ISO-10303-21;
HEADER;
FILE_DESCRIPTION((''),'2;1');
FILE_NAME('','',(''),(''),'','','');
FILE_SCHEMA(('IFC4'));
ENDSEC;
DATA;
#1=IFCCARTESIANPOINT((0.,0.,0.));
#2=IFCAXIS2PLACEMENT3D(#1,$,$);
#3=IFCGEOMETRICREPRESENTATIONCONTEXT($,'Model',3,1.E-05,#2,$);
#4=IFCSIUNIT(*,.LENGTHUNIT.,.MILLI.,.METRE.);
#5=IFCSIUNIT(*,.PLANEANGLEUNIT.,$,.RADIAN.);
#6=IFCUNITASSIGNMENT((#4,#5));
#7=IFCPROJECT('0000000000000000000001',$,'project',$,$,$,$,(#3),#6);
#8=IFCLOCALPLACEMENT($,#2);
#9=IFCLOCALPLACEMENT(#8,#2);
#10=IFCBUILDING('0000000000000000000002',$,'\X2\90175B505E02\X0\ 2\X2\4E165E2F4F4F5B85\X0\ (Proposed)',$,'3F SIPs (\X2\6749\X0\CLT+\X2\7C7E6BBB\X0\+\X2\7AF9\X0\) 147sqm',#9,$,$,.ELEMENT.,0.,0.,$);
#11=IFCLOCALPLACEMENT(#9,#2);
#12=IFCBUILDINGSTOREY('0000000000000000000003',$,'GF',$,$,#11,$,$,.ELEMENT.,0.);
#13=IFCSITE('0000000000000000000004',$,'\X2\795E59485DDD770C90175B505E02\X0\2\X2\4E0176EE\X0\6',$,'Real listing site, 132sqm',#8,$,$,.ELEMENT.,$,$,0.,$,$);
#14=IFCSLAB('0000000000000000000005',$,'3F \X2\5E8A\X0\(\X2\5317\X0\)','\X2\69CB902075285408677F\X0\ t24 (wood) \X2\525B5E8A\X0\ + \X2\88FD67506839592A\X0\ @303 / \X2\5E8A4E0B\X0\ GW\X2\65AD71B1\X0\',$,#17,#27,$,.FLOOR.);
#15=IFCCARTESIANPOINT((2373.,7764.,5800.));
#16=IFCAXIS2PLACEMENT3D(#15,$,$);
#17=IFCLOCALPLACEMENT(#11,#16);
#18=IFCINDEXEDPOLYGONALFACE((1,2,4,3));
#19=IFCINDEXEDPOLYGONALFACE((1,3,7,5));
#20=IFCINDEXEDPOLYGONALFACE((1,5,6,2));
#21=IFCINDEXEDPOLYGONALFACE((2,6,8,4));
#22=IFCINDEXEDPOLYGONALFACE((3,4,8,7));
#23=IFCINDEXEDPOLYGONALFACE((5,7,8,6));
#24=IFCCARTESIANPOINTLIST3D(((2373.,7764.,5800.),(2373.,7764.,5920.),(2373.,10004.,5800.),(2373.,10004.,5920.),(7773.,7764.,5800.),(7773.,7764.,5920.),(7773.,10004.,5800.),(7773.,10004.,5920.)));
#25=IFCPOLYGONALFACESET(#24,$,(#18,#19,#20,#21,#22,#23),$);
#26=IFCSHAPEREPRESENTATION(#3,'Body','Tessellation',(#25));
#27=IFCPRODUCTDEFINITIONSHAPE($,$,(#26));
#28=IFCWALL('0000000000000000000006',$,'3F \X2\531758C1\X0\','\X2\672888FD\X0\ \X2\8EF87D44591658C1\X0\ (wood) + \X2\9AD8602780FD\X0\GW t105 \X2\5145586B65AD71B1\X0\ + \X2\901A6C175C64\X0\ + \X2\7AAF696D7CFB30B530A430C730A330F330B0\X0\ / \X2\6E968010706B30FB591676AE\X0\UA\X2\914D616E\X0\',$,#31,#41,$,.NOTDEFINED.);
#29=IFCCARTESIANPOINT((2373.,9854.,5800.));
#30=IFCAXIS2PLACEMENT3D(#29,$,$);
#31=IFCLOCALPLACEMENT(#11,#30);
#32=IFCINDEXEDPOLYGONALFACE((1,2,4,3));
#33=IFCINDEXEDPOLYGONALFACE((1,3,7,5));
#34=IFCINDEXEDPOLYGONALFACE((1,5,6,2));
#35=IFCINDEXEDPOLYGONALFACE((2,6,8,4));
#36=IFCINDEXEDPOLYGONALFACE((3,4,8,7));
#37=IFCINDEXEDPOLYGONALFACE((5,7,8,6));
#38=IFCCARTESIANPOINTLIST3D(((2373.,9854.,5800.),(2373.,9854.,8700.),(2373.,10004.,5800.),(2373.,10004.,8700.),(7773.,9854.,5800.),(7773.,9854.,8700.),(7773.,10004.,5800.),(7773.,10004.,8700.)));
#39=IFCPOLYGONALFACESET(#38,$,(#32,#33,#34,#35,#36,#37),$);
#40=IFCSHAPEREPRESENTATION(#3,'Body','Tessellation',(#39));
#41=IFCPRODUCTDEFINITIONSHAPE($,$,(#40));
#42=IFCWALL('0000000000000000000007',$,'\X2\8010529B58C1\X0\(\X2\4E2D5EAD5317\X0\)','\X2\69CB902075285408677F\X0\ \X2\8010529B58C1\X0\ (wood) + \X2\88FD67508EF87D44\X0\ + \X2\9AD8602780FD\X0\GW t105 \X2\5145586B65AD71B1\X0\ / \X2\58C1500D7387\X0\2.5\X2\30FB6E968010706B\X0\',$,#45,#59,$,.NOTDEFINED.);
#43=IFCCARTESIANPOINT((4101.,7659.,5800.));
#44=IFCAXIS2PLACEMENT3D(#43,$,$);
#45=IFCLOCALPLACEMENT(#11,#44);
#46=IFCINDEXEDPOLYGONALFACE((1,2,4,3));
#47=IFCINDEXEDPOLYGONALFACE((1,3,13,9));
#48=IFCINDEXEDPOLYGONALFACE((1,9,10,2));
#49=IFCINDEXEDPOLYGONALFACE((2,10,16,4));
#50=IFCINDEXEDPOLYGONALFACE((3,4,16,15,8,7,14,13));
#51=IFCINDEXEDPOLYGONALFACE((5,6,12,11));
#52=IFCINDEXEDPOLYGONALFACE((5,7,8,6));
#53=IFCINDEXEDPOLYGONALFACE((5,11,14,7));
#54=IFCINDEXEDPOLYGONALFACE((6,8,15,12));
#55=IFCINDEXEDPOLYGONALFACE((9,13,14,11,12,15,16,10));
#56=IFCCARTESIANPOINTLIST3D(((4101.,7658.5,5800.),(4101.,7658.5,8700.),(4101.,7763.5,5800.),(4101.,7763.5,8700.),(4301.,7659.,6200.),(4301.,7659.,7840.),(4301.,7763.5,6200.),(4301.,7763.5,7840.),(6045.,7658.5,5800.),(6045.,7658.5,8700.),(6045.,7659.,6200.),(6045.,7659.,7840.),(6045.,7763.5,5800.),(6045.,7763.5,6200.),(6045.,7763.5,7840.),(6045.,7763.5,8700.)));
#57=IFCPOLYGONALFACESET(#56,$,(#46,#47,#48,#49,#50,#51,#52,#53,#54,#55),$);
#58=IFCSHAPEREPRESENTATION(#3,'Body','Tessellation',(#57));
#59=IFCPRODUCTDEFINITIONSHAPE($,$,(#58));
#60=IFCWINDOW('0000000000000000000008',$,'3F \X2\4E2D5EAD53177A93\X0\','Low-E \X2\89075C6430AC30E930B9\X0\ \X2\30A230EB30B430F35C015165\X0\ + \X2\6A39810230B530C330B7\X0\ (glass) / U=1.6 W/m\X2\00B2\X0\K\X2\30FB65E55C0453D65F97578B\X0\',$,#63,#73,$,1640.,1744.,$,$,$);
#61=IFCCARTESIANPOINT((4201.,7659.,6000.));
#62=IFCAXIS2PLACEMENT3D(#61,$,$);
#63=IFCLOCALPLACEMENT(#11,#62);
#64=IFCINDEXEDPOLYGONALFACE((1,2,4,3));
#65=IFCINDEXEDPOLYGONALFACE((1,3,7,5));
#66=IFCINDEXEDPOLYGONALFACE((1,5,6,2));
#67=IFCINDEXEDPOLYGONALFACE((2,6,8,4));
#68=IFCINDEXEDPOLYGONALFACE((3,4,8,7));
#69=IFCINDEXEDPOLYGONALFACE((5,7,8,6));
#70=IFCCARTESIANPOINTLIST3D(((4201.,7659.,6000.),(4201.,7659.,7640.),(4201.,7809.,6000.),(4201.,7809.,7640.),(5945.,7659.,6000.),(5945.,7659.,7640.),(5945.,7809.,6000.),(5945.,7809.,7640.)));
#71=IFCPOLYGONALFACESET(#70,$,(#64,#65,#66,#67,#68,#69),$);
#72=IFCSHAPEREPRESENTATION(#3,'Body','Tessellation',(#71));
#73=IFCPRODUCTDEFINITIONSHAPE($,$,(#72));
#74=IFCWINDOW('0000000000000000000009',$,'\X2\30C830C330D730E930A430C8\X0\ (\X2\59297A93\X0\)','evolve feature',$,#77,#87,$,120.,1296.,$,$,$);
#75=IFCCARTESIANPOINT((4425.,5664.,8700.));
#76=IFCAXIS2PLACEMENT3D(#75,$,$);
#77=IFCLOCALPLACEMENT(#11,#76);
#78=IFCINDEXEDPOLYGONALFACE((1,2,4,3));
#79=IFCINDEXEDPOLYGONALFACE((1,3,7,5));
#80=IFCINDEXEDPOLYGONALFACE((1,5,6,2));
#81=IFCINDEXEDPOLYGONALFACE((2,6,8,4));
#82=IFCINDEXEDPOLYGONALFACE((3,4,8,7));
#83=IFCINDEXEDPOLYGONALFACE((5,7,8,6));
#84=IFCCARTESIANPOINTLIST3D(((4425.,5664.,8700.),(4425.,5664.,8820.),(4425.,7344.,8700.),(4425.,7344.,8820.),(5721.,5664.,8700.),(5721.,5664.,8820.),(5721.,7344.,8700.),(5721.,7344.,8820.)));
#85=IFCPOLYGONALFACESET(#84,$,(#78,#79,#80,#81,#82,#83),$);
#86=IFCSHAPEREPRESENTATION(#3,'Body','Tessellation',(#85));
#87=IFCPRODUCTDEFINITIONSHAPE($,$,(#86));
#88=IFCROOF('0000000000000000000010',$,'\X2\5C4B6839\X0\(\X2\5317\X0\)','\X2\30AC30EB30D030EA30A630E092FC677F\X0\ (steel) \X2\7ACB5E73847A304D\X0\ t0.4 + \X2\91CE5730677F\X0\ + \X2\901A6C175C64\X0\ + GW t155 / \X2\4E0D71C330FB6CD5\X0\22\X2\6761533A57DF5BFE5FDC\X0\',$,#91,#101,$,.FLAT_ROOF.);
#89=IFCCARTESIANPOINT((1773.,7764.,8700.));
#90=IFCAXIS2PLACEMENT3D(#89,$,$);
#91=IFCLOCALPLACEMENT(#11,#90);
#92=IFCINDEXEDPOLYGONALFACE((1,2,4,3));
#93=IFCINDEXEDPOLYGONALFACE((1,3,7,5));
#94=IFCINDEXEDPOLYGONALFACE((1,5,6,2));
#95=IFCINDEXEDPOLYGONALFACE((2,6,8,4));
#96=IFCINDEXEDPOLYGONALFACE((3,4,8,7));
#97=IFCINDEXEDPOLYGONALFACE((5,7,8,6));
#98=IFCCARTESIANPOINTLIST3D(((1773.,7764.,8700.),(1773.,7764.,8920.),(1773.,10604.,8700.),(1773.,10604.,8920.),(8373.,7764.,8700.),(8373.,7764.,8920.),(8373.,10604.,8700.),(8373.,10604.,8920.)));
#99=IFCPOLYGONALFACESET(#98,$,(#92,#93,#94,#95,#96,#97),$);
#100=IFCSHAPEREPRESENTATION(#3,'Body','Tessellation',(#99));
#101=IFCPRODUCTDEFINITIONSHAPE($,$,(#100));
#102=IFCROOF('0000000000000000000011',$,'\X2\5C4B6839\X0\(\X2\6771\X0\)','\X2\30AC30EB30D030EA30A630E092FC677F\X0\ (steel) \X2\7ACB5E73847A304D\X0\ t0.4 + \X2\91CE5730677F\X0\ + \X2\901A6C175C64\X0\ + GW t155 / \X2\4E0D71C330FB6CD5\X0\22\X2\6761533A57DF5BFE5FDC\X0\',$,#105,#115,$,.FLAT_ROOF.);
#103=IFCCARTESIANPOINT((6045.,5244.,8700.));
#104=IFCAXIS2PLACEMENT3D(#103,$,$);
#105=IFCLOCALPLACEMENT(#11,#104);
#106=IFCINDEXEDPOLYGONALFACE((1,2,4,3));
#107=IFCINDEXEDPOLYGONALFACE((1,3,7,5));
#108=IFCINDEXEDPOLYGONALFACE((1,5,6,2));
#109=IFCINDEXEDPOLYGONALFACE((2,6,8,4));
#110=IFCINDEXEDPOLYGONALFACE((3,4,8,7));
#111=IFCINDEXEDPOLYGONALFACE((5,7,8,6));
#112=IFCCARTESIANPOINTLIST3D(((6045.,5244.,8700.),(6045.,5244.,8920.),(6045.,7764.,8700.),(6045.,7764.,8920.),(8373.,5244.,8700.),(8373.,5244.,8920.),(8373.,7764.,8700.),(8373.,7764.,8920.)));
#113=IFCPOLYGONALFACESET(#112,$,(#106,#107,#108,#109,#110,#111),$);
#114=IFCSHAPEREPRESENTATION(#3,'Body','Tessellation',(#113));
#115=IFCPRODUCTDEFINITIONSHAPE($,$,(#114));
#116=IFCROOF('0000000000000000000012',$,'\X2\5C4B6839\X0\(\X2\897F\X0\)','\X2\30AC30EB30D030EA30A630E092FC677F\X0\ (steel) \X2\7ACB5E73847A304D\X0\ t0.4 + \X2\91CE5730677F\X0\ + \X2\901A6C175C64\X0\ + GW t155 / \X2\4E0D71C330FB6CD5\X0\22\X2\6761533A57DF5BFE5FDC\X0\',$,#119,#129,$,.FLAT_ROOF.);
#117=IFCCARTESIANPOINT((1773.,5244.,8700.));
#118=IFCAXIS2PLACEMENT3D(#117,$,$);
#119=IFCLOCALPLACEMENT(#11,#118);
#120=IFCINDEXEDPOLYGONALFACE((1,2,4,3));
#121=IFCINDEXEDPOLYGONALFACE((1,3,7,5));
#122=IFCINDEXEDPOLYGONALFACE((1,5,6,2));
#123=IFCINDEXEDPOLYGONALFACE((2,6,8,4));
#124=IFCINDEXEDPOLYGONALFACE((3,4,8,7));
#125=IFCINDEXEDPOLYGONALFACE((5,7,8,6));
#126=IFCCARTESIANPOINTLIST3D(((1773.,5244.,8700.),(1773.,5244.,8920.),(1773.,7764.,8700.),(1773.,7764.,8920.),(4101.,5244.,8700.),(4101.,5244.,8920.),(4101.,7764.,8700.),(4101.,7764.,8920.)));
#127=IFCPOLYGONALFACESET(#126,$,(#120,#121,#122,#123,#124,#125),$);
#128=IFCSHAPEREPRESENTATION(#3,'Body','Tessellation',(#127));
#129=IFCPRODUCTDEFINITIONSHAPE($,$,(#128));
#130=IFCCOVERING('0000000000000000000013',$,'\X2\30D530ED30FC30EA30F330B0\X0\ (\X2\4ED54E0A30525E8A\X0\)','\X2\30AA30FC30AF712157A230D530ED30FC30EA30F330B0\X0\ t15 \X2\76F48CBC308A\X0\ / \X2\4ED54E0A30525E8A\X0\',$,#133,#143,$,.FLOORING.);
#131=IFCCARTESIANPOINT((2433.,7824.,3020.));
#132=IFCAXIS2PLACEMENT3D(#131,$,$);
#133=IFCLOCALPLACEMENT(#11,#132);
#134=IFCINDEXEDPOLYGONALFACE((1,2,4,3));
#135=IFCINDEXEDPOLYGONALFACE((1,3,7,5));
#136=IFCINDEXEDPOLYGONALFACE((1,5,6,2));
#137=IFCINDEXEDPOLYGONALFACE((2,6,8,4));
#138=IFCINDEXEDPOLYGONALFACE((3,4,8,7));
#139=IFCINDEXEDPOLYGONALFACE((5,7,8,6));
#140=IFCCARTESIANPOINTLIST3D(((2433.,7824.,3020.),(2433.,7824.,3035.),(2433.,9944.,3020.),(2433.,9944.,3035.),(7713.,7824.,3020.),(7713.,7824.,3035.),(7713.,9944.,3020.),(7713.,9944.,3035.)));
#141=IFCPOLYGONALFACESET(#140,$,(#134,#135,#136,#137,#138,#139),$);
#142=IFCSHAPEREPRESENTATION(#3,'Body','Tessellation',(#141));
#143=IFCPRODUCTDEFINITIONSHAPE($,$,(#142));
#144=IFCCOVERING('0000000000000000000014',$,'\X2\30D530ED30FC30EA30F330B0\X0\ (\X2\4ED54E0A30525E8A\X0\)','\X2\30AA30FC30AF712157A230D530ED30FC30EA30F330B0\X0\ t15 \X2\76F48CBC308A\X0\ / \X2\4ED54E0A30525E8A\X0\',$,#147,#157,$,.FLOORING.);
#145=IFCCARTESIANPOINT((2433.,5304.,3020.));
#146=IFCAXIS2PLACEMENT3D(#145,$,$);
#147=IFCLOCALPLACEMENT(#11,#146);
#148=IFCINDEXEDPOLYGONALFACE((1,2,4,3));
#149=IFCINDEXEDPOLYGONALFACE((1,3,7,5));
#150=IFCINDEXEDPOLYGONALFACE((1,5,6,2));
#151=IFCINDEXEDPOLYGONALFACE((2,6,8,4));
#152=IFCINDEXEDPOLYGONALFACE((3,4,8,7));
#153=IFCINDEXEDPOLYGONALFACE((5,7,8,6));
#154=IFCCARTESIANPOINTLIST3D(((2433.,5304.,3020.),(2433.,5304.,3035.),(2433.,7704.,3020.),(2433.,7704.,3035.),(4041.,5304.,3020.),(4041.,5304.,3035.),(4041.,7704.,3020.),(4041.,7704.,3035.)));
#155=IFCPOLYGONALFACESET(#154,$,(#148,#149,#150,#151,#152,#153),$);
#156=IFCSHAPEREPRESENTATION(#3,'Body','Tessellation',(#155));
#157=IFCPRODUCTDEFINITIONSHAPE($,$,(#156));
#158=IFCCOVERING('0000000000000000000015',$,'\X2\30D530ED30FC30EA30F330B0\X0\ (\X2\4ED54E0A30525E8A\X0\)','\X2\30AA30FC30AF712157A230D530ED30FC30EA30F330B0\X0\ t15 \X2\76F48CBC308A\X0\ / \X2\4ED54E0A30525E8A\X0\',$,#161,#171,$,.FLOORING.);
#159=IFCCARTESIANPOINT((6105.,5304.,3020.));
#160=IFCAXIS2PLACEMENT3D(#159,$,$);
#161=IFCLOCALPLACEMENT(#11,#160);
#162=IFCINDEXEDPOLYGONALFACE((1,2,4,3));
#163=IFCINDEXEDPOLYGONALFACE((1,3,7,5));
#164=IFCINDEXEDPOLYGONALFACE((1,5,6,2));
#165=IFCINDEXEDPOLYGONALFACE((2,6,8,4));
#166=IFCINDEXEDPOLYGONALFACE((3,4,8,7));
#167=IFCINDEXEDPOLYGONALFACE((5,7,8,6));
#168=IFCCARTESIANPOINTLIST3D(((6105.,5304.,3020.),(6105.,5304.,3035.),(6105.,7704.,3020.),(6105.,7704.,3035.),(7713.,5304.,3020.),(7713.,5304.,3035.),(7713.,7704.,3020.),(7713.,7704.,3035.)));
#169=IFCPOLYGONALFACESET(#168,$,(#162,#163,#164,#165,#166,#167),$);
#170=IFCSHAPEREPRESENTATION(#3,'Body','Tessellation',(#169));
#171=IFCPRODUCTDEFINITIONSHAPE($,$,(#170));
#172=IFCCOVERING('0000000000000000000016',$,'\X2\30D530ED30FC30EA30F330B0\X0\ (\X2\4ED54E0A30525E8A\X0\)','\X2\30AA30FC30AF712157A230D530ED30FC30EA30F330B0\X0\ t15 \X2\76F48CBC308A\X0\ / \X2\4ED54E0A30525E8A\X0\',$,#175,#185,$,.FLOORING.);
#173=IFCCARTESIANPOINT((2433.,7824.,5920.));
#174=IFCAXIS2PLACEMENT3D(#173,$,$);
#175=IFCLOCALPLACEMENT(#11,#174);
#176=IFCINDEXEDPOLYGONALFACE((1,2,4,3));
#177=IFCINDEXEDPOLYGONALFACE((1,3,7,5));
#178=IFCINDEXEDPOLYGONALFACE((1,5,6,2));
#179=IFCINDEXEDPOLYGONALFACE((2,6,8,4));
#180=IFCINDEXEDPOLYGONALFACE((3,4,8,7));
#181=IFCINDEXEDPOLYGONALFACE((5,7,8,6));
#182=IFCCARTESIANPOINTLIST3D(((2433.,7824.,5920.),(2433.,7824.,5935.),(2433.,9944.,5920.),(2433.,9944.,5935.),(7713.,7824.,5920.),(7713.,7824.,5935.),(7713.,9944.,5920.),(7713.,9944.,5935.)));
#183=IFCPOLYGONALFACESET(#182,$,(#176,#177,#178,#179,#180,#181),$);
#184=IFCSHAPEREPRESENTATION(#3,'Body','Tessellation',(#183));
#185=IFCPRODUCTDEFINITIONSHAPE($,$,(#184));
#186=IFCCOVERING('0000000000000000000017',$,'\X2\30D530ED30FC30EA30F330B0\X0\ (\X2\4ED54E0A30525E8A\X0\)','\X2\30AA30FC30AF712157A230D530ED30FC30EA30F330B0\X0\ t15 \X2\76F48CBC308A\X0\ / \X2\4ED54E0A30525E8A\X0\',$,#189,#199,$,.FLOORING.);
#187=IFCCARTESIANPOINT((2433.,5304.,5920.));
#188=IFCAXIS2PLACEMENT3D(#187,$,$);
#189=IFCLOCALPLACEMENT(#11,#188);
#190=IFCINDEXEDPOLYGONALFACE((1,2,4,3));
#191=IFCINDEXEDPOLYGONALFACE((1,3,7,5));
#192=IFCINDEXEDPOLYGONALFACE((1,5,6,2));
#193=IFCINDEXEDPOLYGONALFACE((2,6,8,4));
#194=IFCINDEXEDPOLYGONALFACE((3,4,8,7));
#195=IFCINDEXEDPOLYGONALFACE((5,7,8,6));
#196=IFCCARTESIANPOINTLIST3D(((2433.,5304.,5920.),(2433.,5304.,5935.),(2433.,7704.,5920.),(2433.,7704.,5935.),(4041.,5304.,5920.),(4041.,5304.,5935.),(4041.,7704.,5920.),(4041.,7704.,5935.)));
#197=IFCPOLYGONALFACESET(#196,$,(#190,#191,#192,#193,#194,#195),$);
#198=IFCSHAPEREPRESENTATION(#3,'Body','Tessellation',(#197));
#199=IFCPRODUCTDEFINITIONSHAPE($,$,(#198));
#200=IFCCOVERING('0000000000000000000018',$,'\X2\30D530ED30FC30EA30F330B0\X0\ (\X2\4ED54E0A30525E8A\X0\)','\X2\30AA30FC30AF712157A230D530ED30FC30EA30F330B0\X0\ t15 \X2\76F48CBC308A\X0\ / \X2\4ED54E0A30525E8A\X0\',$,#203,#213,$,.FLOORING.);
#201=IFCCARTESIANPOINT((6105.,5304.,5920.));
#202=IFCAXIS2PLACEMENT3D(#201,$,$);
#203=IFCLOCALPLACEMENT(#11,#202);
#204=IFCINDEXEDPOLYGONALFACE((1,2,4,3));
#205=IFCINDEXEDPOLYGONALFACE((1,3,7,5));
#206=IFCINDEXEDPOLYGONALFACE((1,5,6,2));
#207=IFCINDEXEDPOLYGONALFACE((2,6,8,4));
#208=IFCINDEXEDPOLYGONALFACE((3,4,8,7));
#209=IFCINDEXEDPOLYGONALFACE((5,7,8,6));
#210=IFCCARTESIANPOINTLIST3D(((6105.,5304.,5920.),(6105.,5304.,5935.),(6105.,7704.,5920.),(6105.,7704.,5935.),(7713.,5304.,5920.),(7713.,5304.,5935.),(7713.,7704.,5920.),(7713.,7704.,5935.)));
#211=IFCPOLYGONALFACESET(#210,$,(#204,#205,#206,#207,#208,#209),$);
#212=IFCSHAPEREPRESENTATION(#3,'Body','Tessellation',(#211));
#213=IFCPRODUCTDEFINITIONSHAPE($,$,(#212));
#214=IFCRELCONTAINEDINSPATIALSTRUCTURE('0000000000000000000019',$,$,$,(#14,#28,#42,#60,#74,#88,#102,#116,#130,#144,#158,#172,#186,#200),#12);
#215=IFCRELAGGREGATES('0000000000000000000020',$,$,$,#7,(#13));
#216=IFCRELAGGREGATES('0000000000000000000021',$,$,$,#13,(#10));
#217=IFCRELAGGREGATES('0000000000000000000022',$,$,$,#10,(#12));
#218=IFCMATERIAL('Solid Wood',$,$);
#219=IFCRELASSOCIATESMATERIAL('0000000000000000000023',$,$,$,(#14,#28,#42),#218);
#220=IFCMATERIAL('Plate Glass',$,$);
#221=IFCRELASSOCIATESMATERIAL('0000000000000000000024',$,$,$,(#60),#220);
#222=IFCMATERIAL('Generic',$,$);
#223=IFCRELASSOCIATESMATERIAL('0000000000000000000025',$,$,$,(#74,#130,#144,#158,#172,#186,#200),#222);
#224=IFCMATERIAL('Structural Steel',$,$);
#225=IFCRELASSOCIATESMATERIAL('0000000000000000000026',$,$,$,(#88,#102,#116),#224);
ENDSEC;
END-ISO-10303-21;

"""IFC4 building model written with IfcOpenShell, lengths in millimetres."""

from ifc_helpers import new_model, si_unit, frame, frame_2d, origin, place, context, project, spatial, rectangle, extrude, material, element, fill, save


model = new_model("IFC4")

# Units and contexts
model_context = context("Model", 3, precision=1e-05, world=origin())
ifc_project = project(units=[si_unit("LENGTHUNIT", "METRE", prefix="MILLI"), si_unit("PLANEANGLEUNIT", "RADIAN")], contexts=[model_context])

# Site, building, storey
site_placement = place(None, origin())
site = spatial("IfcSite", under=ifc_project, at=site_placement, Name="神奈川県逗子市2丁目6", ObjectType="Real listing site, 132sqm", CompositionType="ELEMENT", RefElevation=0.0)
building_placement = place(site_placement, origin())
building = spatial("IfcBuilding", under=site, at=building_placement, Name="逗子市 2世帯住宅 (Proposed)", ObjectType="3F SIPs (杉CLT+籾殻+竹) 147sqm", CompositionType="ELEMENT", ElevationOfRefHeight=0.0, ElevationOfTerrain=0.0)
storey_placement = place(building_placement, origin())
storey = spatial("IfcBuildingStorey", under=building, at=storey_placement, Name="GF", CompositionType="ELEMENT", Elevation=0.0)

# Slab
ifc_material_1 = material(Name="Solid Wood")
slab_placement = place(storey_placement, frame((2373.0, 7764.0, 5800.0)))
element("IfcSlab", 1, at=slab_placement, inside=storey, material=ifc_material_1, Name="3F 床(北)", Description="構造用合板 t24 (wood) 剛床 + 製材根太 @303 / 床下 GW断熱", PredefinedType="FLOOR", context=model_context, shape_type="SweptSolid", body=[
    extrude(rectangle(XDim=5400.0, YDim=2240.0, at=frame_2d((2700.0, 1120.0))), frame((2373.0, 7764.0, 5800.0)), (0.0, 0.0, 1.0), 120.0),
])

# Wall
wall_1_placement = place(storey_placement, frame((2373.0, 9854.0, 5800.0)))
element("IfcWall", 2, at=wall_1_placement, inside=storey, material=ifc_material_1, Name="3F 北壁", Description="木製 軸組外壁 (wood) + 高性能GW t105 充填断熱 + 通気層 + 窯業系サイディング / 準耐火・外皮UA配慮", PredefinedType="NOTDEFINED", context=model_context, shape_type="SweptSolid", body=[
    extrude(rectangle(XDim=5400.0, YDim=150.0, at=frame_2d((2700.0, 75.0))), frame((2373.0, 9854.0, 5800.0)), (0.0, 0.0, 1.0), 2900.0),
])

# Wall, opening, window
wall_2_placement = place(storey_placement, frame((4101.0, 7659.0, 5800.0)))
wall_2 = element("IfcWall", 3, at=wall_2_placement, inside=storey, material=ifc_material_1, Name="耐力壁(中庭北)", Description="構造用合板 耐力壁 (wood) + 製材軸組 + 高性能GW t105 充填断熱 / 壁倍率2.5・準耐火", PredefinedType="NOTDEFINED", context=model_context, shape_type="SweptSolid", body=[
    extrude(rectangle(XDim=1944.0, YDim=105.0, at=frame_2d((972.0, 52.0))), frame((4101.0, 7659.0, 5800.0)), (0.0, 0.0, 1.0), 2900.0),
])
opening_placement = place(storey_placement, frame((4201.0, 7659.0, 6000.0)))
opening = element("IfcOpeningElement", 4, at=opening_placement, cuts=wall_2, PredefinedType="NOTDEFINED", context=model_context, shape_type="SweptSolid", body=[
    extrude(rectangle(XDim=1744.0, YDim=150.0, at=frame_2d((872.0, 75.0))), frame((4201.0, 7659.0, 6000.0)), (0.0, 0.0, 1.0), 1640.0),
])
ifc_material_2 = material(Name="Plate Glass")
window_1_placement = place(storey_placement, frame((4201.0, 7659.0, 6000.0)))
window_1 = element("IfcWindow", 5, at=window_1_placement, inside=storey, material=ifc_material_2, Name="3F 中庭北窓", Description="Low-E 複層ガラス アルゴン封入 + 樹脂サッシ (glass) / U=1.6 W/m²K・日射取得型", OverallHeight=1640.0, OverallWidth=1744.0, context=model_context, shape_type="SweptSolid", body=[
    extrude(rectangle(XDim=1744.0, YDim=150.0, at=frame_2d((872.0, 75.0))), frame((4201.0, 7659.0, 6000.0)), (0.0, 0.0, 1.0), 1640.0),
])
fill(opening, window_1)

# Window
ifc_material_3 = material(Name="Generic")
window_2_placement = place(storey_placement, frame((4425.0, 5664.0, 8700.0)))
element("IfcWindow", 6, at=window_2_placement, inside=storey, material=ifc_material_3, Name="トップライト (天窓)", Description="evolve feature", OverallHeight=120.0, OverallWidth=1296.0, context=model_context, shape_type="SweptSolid", body=[
    extrude(rectangle(XDim=1296.0, YDim=1680.0, at=frame_2d((648.0, 840.0))), frame((4425.0, 5664.0, 8700.0)), (0.0, 0.0, 1.0), 120.0),
])

# Roofs
ifc_material_4 = material(Name="Structural Steel")
roof_1_placement = place(storey_placement, frame((1773.0, 7764.0, 8700.0)))
element("IfcRoof", 7, at=roof_1_placement, inside=storey, material=ifc_material_4, Name="屋根(北)", Description="ガルバリウム鋼板 (steel) 立平葺き t0.4 + 野地板 + 通気層 + GW t155 / 不燃・法22条区域対応", PredefinedType="FLAT_ROOF", context=model_context, shape_type="SweptSolid", body=[
    extrude(rectangle(XDim=6600.0, YDim=2840.0, at=frame_2d((3300.0, 1420.0))), frame((1773.0, 7764.0, 8700.0)), (0.0, 0.0, 1.0), 220.0),
])
roof_2_placement = place(storey_placement, frame((6045.0, 5244.0, 8700.0)))
element("IfcRoof", 8, at=roof_2_placement, inside=storey, material=ifc_material_4, Name="屋根(東)", Description="ガルバリウム鋼板 (steel) 立平葺き t0.4 + 野地板 + 通気層 + GW t155 / 不燃・法22条区域対応", PredefinedType="FLAT_ROOF", context=model_context, shape_type="SweptSolid", body=[
    extrude(rectangle(XDim=2328.0, YDim=2520.0, at=frame_2d((1164.0, 1260.0))), frame((6045.0, 5244.0, 8700.0)), (0.0, 0.0, 1.0), 220.0),
])
roof_3_placement = place(storey_placement, frame((1773.0, 5244.0, 8700.0)))
element("IfcRoof", 9, at=roof_3_placement, inside=storey, material=ifc_material_4, Name="屋根(西)", Description="ガルバリウム鋼板 (steel) 立平葺き t0.4 + 野地板 + 通気層 + GW t155 / 不燃・法22条区域対応", PredefinedType="FLAT_ROOF", context=model_context, shape_type="SweptSolid", body=[
    extrude(rectangle(XDim=2328.0, YDim=2520.0, at=frame_2d((1164.0, 1260.0))), frame((1773.0, 5244.0, 8700.0)), (0.0, 0.0, 1.0), 220.0),
])

# Coverings
covering_1_placement = place(storey_placement, frame((2433.0, 7824.0, 3020.0)))
element("IfcCovering", 10, at=covering_1_placement, inside=storey, material=ifc_material_3, Name="フローリング (仕上げ床)", Description="オーク無垢フローリング t15 直貼り / 仕上げ床", PredefinedType="FLOORING", context=model_context, shape_type="SweptSolid", body=[
    extrude(rectangle(XDim=5280.0, YDim=2120.0, at=frame_2d((2640.0, 1060.0))), frame((2433.0, 7824.0, 3020.0)), (0.0, 0.0, 1.0), 15.0),
])
covering_2_placement = place(storey_placement, frame((2433.0, 5304.0, 3020.0)))
element("IfcCovering", 11, at=covering_2_placement, inside=storey, material=ifc_material_3, Name="フローリング (仕上げ床)", Description="オーク無垢フローリング t15 直貼り / 仕上げ床", PredefinedType="FLOORING", context=model_context, shape_type="SweptSolid", body=[
    extrude(rectangle(XDim=1608.0, YDim=2400.0, at=frame_2d((804.0, 1200.0))), frame((2433.0, 5304.0, 3020.0)), (0.0, 0.0, 1.0), 15.0),
])
covering_3_placement = place(storey_placement, frame((6105.0, 5304.0, 3020.0)))
element("IfcCovering", 12, at=covering_3_placement, inside=storey, material=ifc_material_3, Name="フローリング (仕上げ床)", Description="オーク無垢フローリング t15 直貼り / 仕上げ床", PredefinedType="FLOORING", context=model_context, shape_type="SweptSolid", body=[
    extrude(rectangle(XDim=1608.0, YDim=2400.0, at=frame_2d((804.0, 1200.0))), frame((6105.0, 5304.0, 3020.0)), (0.0, 0.0, 1.0), 15.0),
])
covering_4_placement = place(storey_placement, frame((2433.0, 7824.0, 5920.0)))
element("IfcCovering", 13, at=covering_4_placement, inside=storey, material=ifc_material_3, Name="フローリング (仕上げ床)", Description="オーク無垢フローリング t15 直貼り / 仕上げ床", PredefinedType="FLOORING", context=model_context, shape_type="SweptSolid", body=[
    extrude(rectangle(XDim=5280.0, YDim=2120.0, at=frame_2d((2640.0, 1060.0))), frame((2433.0, 7824.0, 5920.0)), (0.0, 0.0, 1.0), 15.0),
])
covering_5_placement = place(storey_placement, frame((2433.0, 5304.0, 5920.0)))
element("IfcCovering", 14, at=covering_5_placement, inside=storey, material=ifc_material_3, Name="フローリング (仕上げ床)", Description="オーク無垢フローリング t15 直貼り / 仕上げ床", PredefinedType="FLOORING", context=model_context, shape_type="SweptSolid", body=[
    extrude(rectangle(XDim=1608.0, YDim=2400.0, at=frame_2d((804.0, 1200.0))), frame((2433.0, 5304.0, 5920.0)), (0.0, 0.0, 1.0), 15.0),
])
covering_6_placement = place(storey_placement, frame((6105.0, 5304.0, 5920.0)))
element("IfcCovering", 15, at=covering_6_placement, inside=storey, material=ifc_material_3, Name="フローリング (仕上げ床)", Description="オーク無垢フローリング t15 直貼り / 仕上げ床", PredefinedType="FLOORING", context=model_context, shape_type="SweptSolid", body=[
    extrude(rectangle(XDim=1608.0, YDim=2400.0, at=frame_2d((804.0, 1200.0))), frame((6105.0, 5304.0, 5920.0)), (0.0, 0.0, 1.0), 15.0),
])

save(model, "model.ifc")
